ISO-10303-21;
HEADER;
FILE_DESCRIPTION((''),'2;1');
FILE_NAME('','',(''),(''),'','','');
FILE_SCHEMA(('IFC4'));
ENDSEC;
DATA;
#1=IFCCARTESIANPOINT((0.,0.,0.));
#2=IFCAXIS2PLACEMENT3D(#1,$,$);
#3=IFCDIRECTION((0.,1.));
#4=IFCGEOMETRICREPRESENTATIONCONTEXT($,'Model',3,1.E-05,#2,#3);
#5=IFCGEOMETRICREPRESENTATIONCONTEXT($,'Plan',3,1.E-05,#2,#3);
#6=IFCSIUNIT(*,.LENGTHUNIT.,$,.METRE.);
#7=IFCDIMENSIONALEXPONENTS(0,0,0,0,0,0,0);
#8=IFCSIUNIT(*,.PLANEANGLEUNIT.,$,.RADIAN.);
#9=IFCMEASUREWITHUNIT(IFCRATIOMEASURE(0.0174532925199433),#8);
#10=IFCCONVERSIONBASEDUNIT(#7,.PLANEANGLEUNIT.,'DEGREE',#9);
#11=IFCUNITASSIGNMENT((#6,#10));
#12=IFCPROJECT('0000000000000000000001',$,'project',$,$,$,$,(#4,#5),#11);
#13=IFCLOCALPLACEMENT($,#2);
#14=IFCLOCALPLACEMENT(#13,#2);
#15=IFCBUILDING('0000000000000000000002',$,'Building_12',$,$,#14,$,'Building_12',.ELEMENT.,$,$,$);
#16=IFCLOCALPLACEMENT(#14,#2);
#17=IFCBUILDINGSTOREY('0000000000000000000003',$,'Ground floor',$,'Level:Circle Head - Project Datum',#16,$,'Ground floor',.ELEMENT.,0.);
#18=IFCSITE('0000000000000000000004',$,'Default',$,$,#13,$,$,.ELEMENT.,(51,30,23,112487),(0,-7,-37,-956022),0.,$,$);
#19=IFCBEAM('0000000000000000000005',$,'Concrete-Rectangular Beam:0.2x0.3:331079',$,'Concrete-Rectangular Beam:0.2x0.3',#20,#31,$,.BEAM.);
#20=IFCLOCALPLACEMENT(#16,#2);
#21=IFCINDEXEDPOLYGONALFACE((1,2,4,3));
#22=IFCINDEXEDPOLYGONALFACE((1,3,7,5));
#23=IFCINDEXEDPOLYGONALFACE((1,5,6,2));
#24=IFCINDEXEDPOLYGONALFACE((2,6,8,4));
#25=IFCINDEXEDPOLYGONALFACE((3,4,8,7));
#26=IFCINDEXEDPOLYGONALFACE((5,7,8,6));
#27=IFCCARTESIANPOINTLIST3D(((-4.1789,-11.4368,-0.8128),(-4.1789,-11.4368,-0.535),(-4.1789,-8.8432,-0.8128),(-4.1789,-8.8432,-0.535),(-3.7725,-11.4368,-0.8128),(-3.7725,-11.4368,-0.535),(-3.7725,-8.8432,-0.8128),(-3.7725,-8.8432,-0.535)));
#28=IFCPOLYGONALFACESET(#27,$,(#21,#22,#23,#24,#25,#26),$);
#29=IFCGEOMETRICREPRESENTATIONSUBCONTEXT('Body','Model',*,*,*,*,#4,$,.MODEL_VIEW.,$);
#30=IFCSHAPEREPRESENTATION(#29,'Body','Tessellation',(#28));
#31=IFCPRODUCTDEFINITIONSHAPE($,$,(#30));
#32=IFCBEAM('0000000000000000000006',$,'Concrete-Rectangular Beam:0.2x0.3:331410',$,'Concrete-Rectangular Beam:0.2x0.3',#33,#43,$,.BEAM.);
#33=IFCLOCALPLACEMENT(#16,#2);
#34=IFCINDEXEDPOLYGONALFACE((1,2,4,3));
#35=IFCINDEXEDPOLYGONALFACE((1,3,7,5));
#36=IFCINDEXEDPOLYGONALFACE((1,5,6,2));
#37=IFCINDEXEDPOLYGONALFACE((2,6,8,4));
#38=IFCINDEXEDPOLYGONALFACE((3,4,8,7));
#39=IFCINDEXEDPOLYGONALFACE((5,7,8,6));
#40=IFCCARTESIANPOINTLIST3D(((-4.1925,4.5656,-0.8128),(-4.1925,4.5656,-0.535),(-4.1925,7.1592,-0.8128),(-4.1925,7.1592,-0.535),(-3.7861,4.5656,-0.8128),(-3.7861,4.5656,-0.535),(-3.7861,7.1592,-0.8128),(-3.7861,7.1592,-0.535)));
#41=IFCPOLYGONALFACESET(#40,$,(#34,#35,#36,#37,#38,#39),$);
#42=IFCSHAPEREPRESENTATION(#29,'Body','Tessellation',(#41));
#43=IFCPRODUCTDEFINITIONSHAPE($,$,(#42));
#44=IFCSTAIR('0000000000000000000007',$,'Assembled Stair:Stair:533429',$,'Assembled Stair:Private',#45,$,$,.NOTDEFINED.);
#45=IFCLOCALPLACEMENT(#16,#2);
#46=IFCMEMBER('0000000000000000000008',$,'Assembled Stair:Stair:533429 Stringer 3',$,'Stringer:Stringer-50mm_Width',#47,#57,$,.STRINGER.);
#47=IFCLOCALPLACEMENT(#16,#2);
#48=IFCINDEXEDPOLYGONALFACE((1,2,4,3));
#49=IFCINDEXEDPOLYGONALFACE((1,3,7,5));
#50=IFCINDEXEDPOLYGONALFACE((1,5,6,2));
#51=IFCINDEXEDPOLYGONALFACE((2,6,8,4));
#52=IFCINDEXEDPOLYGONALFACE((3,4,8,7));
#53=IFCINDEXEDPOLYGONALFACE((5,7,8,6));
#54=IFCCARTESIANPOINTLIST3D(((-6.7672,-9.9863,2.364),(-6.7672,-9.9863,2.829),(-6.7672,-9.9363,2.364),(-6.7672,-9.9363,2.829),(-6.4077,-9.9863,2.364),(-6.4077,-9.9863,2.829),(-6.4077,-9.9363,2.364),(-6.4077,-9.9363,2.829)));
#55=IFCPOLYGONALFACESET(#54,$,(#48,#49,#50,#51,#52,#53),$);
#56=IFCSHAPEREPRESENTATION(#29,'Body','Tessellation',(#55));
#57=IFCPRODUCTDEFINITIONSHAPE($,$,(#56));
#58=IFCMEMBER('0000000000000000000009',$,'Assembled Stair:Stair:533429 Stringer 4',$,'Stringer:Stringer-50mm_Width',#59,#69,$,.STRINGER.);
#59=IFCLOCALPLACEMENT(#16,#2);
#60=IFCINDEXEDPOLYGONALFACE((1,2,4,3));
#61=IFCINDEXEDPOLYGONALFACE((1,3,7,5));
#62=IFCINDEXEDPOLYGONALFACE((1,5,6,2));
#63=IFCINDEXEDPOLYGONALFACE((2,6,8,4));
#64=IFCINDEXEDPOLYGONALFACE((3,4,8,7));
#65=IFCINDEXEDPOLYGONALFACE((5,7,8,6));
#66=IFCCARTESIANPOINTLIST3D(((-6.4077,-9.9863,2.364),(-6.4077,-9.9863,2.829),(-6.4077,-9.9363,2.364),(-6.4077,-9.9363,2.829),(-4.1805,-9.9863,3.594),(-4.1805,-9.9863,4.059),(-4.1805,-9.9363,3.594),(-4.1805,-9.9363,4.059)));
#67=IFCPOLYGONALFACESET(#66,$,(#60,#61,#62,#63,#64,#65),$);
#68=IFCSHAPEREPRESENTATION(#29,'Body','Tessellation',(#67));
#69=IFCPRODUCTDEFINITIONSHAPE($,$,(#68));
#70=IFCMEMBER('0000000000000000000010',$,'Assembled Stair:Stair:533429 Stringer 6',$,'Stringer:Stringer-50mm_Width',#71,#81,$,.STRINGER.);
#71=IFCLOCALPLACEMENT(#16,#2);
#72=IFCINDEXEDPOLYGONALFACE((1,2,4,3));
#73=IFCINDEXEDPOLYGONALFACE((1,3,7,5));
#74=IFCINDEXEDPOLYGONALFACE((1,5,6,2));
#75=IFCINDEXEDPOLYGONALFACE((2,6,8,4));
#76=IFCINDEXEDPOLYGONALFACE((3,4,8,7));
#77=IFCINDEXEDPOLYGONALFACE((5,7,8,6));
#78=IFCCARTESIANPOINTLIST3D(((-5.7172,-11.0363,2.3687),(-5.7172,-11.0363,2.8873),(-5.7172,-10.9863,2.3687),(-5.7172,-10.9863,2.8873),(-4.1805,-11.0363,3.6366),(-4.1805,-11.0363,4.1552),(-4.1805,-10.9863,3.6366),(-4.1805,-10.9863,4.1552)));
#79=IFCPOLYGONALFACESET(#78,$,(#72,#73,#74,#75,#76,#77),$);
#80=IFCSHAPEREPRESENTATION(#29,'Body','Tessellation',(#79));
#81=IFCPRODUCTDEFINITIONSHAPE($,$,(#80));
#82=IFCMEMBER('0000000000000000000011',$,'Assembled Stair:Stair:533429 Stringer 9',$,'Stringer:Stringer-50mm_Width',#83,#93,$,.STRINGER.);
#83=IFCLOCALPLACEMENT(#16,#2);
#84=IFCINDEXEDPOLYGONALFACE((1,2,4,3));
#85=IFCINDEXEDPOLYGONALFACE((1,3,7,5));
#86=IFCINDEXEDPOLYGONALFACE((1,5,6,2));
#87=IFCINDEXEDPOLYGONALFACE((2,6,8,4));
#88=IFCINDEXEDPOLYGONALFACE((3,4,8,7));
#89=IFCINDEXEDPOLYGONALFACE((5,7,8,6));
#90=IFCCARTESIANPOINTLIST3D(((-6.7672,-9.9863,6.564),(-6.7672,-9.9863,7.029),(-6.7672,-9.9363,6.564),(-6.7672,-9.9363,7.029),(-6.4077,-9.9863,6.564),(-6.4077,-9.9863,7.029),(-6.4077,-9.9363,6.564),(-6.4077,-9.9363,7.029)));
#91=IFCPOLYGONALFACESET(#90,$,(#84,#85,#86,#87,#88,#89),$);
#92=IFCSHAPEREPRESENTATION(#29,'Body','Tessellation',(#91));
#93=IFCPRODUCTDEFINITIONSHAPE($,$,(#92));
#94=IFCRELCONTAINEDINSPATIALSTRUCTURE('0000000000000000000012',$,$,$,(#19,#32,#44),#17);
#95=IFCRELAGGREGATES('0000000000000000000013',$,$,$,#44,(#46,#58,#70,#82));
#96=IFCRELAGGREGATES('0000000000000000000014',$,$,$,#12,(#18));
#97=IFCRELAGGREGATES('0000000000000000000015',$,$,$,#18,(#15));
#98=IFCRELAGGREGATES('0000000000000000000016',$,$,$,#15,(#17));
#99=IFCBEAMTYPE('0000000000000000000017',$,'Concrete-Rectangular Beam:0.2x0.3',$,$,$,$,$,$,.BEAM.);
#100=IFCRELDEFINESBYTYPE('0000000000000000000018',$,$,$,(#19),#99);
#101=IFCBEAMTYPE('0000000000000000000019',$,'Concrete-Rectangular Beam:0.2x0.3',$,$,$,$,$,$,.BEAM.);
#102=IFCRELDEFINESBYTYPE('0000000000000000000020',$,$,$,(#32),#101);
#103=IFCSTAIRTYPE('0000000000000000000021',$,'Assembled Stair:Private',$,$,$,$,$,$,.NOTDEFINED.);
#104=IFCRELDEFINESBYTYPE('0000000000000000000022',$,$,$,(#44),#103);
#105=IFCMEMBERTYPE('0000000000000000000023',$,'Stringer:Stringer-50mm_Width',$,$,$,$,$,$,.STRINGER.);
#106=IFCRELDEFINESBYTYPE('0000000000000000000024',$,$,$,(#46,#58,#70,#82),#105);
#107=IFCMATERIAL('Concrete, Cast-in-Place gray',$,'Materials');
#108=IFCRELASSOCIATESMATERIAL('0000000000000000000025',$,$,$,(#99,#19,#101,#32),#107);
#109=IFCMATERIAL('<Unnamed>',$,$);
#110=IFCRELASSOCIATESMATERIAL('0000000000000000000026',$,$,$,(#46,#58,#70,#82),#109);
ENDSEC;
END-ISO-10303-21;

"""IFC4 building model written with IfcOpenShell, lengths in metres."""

from ifc_helpers import new_model, entity, si_unit, converted_unit, direction, frame, origin, place, context, subcontext, project, spatial, indexed_curve, outline, extrude, source, transform, mapped, material, type_object, type_shapes, element, aggregate, save


model = new_model("IFC4")

# Units and contexts
model_context = context("Model", 3, precision=1e-05, world=origin(), true_north=direction((0.0, 1.0)))
plan_context = context("Plan", 3, precision=1e-05, world=origin(), true_north=direction((0.0, 1.0)))
body_context = subcontext(model_context, "Body", "Model", "MODEL_VIEW")
ifc_project = project(units=[si_unit("LENGTHUNIT", "METRE"), converted_unit("PLANEANGLEUNIT", "DEGREE", entity("IfcRatioMeasure", 0.0174532925199433), si_unit("PLANEANGLEUNIT", "RADIAN"), dimensions=[0, 0, 0, 0, 0, 0, 0])], contexts=[model_context, plan_context])

# Site, building, storey
site_placement = place(None, origin())
site = spatial("IfcSite", under=ifc_project, at=site_placement, Name="Default", CompositionType="ELEMENT", RefLatitude=(51, 30, 23, 112487), RefLongitude=(0, -7, -37, -956022), RefElevation=0.0)
building_placement = place(site_placement, origin())
building = spatial("IfcBuilding", under=site, at=building_placement, Name="Building_12", LongName="Building_12", CompositionType="ELEMENT")
storey_placement = place(building_placement, origin())
storey = spatial("IfcBuildingStorey", under=building, at=storey_placement, Name="Ground floor", ObjectType="Level:Circle Head - Project Datum", LongName="Ground floor", CompositionType="ELEMENT", Elevation=0.0)

# Beams
ifc_material_1 = material(Name="Concrete, Cast-in-Place gray", Category="Materials")
beam_type_1 = type_object("IfcBeamType", Name="Concrete-Rectangular Beam:0.2x0.3", PredefinedType="BEAM", material=ifc_material_1)
shared_shape_1 = source(origin(), body_context, "Body", "SweptSolid", [
    extrude(outline(indexed_curve([(-0.2032, -0.1389), (0.2032, -0.1389), (0.2032, 0.1389), (-0.2032, 0.1389), (-0.2032, -0.1389)], self_intersect=False)), frame((-3.9757, -8.8432, -0.6739), z_axis=(0.0, -1.0, 0.0), x_axis=(-1.0, 0.0, 0.0)), (0.0, 0.0, 1.0), 2.5936),
])
type_shapes(beam_type_1, [shared_shape_1])
beam_1_placement = place(storey_placement, origin())
element("IfcBeam", 1, at=beam_1_placement, inside=storey, type_object=beam_type_1, material=ifc_material_1, Name="Concrete-Rectangular Beam:0.2x0.3:331079", ObjectType="Concrete-Rectangular Beam:0.2x0.3", PredefinedType="BEAM", context=body_context, shape_type="MappedRepresentation", body=[
    mapped(shared_shape_1, transform((0.0, 0.0, 0.0), scale=1.0)),
])
beam_type_2 = type_object("IfcBeamType", Name="Concrete-Rectangular Beam:0.2x0.3", PredefinedType="BEAM", material=ifc_material_1)
shared_shape_2 = source(origin(), body_context, "Body", "SweptSolid", [
    extrude(outline(indexed_curve([(-0.2032, -0.1389), (0.2032, -0.1389), (0.2032, 0.1389), (-0.2032, 0.1389), (-0.2032, -0.1389)], self_intersect=False)), frame((-3.9893, 7.1592, -0.6739), z_axis=(0.0, -1.0, 0.0), x_axis=(-1.0, 0.0, 0.0)), (0.0, 0.0, 1.0), 2.5936),
])
type_shapes(beam_type_2, [shared_shape_2])
beam_2_placement = place(storey_placement, origin())
element("IfcBeam", 2, at=beam_2_placement, inside=storey, type_object=beam_type_2, material=ifc_material_1, Name="Concrete-Rectangular Beam:0.2x0.3:331410", ObjectType="Concrete-Rectangular Beam:0.2x0.3", PredefinedType="BEAM", context=body_context, shape_type="MappedRepresentation", body=[
    mapped(shared_shape_2, transform((0.0, 0.0, 0.0), scale=1.0)),
])

# Stair, members
stair_type = type_object("IfcStairType", Name="Assembled Stair:Private", PredefinedType="NOTDEFINED")
stair_placement = place(storey_placement, origin())
stair = element("IfcStair", 3, at=stair_placement, inside=storey, type_object=stair_type, Name="Assembled Stair:Stair:533429", ObjectType="Assembled Stair:Private", PredefinedType="NOTDEFINED")
ifc_material_2 = material(Name="<Unnamed>")
member_type = type_object("IfcMemberType", Name="Stringer:Stringer-50mm_Width", PredefinedType="STRINGER")
member_1_placement = place(stair_placement, origin())
member_1 = element("IfcMember", 4, at=member_1_placement, type_object=member_type, material=ifc_material_2, Name="Assembled Stair:Stair:533429 Stringer 3", ObjectType="Stringer:Stringer-50mm_Width", PredefinedType="STRINGER", context=body_context, shape_type="SweptSolid", body=[
    extrude(outline(indexed_curve([(-0.1797, -0.025), (0.1797, -0.025), (0.1797, 0.025), (-0.1797, 0.025), (-0.1797, -0.025)], self_intersect=False)), frame((-6.5874, -9.9613, 2.364)), (0.0, 0.0, 1.0), 0.465),
])
member_2_placement = place(stair_placement, origin())
member_2 = element("IfcMember", 5, at=member_2_placement, type_object=member_type, material=ifc_material_2, Name="Assembled Stair:Stair:533429 Stringer 4", ObjectType="Stringer:Stringer-50mm_Width", PredefinedType="STRINGER", context=body_context, shape_type="SweptSolid", body=[
    extrude(outline(indexed_curve([(-1.1598, -0.2035), (1.3846, -0.2035), (1.1598, 0.2035), (-1.3846, 0.2035), (-1.1598, -0.2035)], self_intersect=False)), frame((-5.2941, -9.9863, 3.2115), z_axis=(0.0, 1.0, 0.0), x_axis=(0.87537, 0.0, 0.483454)), (0.0, 0.0, 1.0), 0.05),
])
member_3_placement = place(stair_placement, origin())
member_3 = element("IfcMember", 6, at=member_3_placement, type_object=member_type, material=ifc_material_2, Name="Assembled Stair:Stair:533429 Stringer 6", ObjectType="Stringer:Stringer-50mm_Width", PredefinedType="STRINGER", context=body_context, shape_type="SweptSolid", body=[
    extrude(outline(indexed_curve([(-0.8311, -0.2), (1.1612, -0.2), (0.8311, 0.2), (-1.1612, 0.2), (-0.8311, -0.2)], self_intersect=False)), frame((-4.9488, -11.0363, 3.262), z_axis=(0.0, 1.0, 0.0), x_axis=(0.771336, 0.0, 0.636428)), (0.0, 0.0, 1.0), 0.05),
])
member_4_placement = place(stair_placement, origin())
member_4 = element("IfcMember", 7, at=member_4_placement, type_object=member_type, material=ifc_material_2, Name="Assembled Stair:Stair:533429 Stringer 9", ObjectType="Stringer:Stringer-50mm_Width", PredefinedType="STRINGER", context=body_context, shape_type="SweptSolid", body=[
    extrude(outline(indexed_curve([(-0.1797, -0.025), (0.1797, -0.025), (0.1797, 0.025), (-0.1797, 0.025), (-0.1797, -0.025)], self_intersect=False)), frame((-6.5874, -9.9613, 6.564)), (0.0, 0.0, 1.0), 0.465),
])
aggregate(stair, [member_1, member_2, member_3, member_4])

save(model, "model.ifc")
